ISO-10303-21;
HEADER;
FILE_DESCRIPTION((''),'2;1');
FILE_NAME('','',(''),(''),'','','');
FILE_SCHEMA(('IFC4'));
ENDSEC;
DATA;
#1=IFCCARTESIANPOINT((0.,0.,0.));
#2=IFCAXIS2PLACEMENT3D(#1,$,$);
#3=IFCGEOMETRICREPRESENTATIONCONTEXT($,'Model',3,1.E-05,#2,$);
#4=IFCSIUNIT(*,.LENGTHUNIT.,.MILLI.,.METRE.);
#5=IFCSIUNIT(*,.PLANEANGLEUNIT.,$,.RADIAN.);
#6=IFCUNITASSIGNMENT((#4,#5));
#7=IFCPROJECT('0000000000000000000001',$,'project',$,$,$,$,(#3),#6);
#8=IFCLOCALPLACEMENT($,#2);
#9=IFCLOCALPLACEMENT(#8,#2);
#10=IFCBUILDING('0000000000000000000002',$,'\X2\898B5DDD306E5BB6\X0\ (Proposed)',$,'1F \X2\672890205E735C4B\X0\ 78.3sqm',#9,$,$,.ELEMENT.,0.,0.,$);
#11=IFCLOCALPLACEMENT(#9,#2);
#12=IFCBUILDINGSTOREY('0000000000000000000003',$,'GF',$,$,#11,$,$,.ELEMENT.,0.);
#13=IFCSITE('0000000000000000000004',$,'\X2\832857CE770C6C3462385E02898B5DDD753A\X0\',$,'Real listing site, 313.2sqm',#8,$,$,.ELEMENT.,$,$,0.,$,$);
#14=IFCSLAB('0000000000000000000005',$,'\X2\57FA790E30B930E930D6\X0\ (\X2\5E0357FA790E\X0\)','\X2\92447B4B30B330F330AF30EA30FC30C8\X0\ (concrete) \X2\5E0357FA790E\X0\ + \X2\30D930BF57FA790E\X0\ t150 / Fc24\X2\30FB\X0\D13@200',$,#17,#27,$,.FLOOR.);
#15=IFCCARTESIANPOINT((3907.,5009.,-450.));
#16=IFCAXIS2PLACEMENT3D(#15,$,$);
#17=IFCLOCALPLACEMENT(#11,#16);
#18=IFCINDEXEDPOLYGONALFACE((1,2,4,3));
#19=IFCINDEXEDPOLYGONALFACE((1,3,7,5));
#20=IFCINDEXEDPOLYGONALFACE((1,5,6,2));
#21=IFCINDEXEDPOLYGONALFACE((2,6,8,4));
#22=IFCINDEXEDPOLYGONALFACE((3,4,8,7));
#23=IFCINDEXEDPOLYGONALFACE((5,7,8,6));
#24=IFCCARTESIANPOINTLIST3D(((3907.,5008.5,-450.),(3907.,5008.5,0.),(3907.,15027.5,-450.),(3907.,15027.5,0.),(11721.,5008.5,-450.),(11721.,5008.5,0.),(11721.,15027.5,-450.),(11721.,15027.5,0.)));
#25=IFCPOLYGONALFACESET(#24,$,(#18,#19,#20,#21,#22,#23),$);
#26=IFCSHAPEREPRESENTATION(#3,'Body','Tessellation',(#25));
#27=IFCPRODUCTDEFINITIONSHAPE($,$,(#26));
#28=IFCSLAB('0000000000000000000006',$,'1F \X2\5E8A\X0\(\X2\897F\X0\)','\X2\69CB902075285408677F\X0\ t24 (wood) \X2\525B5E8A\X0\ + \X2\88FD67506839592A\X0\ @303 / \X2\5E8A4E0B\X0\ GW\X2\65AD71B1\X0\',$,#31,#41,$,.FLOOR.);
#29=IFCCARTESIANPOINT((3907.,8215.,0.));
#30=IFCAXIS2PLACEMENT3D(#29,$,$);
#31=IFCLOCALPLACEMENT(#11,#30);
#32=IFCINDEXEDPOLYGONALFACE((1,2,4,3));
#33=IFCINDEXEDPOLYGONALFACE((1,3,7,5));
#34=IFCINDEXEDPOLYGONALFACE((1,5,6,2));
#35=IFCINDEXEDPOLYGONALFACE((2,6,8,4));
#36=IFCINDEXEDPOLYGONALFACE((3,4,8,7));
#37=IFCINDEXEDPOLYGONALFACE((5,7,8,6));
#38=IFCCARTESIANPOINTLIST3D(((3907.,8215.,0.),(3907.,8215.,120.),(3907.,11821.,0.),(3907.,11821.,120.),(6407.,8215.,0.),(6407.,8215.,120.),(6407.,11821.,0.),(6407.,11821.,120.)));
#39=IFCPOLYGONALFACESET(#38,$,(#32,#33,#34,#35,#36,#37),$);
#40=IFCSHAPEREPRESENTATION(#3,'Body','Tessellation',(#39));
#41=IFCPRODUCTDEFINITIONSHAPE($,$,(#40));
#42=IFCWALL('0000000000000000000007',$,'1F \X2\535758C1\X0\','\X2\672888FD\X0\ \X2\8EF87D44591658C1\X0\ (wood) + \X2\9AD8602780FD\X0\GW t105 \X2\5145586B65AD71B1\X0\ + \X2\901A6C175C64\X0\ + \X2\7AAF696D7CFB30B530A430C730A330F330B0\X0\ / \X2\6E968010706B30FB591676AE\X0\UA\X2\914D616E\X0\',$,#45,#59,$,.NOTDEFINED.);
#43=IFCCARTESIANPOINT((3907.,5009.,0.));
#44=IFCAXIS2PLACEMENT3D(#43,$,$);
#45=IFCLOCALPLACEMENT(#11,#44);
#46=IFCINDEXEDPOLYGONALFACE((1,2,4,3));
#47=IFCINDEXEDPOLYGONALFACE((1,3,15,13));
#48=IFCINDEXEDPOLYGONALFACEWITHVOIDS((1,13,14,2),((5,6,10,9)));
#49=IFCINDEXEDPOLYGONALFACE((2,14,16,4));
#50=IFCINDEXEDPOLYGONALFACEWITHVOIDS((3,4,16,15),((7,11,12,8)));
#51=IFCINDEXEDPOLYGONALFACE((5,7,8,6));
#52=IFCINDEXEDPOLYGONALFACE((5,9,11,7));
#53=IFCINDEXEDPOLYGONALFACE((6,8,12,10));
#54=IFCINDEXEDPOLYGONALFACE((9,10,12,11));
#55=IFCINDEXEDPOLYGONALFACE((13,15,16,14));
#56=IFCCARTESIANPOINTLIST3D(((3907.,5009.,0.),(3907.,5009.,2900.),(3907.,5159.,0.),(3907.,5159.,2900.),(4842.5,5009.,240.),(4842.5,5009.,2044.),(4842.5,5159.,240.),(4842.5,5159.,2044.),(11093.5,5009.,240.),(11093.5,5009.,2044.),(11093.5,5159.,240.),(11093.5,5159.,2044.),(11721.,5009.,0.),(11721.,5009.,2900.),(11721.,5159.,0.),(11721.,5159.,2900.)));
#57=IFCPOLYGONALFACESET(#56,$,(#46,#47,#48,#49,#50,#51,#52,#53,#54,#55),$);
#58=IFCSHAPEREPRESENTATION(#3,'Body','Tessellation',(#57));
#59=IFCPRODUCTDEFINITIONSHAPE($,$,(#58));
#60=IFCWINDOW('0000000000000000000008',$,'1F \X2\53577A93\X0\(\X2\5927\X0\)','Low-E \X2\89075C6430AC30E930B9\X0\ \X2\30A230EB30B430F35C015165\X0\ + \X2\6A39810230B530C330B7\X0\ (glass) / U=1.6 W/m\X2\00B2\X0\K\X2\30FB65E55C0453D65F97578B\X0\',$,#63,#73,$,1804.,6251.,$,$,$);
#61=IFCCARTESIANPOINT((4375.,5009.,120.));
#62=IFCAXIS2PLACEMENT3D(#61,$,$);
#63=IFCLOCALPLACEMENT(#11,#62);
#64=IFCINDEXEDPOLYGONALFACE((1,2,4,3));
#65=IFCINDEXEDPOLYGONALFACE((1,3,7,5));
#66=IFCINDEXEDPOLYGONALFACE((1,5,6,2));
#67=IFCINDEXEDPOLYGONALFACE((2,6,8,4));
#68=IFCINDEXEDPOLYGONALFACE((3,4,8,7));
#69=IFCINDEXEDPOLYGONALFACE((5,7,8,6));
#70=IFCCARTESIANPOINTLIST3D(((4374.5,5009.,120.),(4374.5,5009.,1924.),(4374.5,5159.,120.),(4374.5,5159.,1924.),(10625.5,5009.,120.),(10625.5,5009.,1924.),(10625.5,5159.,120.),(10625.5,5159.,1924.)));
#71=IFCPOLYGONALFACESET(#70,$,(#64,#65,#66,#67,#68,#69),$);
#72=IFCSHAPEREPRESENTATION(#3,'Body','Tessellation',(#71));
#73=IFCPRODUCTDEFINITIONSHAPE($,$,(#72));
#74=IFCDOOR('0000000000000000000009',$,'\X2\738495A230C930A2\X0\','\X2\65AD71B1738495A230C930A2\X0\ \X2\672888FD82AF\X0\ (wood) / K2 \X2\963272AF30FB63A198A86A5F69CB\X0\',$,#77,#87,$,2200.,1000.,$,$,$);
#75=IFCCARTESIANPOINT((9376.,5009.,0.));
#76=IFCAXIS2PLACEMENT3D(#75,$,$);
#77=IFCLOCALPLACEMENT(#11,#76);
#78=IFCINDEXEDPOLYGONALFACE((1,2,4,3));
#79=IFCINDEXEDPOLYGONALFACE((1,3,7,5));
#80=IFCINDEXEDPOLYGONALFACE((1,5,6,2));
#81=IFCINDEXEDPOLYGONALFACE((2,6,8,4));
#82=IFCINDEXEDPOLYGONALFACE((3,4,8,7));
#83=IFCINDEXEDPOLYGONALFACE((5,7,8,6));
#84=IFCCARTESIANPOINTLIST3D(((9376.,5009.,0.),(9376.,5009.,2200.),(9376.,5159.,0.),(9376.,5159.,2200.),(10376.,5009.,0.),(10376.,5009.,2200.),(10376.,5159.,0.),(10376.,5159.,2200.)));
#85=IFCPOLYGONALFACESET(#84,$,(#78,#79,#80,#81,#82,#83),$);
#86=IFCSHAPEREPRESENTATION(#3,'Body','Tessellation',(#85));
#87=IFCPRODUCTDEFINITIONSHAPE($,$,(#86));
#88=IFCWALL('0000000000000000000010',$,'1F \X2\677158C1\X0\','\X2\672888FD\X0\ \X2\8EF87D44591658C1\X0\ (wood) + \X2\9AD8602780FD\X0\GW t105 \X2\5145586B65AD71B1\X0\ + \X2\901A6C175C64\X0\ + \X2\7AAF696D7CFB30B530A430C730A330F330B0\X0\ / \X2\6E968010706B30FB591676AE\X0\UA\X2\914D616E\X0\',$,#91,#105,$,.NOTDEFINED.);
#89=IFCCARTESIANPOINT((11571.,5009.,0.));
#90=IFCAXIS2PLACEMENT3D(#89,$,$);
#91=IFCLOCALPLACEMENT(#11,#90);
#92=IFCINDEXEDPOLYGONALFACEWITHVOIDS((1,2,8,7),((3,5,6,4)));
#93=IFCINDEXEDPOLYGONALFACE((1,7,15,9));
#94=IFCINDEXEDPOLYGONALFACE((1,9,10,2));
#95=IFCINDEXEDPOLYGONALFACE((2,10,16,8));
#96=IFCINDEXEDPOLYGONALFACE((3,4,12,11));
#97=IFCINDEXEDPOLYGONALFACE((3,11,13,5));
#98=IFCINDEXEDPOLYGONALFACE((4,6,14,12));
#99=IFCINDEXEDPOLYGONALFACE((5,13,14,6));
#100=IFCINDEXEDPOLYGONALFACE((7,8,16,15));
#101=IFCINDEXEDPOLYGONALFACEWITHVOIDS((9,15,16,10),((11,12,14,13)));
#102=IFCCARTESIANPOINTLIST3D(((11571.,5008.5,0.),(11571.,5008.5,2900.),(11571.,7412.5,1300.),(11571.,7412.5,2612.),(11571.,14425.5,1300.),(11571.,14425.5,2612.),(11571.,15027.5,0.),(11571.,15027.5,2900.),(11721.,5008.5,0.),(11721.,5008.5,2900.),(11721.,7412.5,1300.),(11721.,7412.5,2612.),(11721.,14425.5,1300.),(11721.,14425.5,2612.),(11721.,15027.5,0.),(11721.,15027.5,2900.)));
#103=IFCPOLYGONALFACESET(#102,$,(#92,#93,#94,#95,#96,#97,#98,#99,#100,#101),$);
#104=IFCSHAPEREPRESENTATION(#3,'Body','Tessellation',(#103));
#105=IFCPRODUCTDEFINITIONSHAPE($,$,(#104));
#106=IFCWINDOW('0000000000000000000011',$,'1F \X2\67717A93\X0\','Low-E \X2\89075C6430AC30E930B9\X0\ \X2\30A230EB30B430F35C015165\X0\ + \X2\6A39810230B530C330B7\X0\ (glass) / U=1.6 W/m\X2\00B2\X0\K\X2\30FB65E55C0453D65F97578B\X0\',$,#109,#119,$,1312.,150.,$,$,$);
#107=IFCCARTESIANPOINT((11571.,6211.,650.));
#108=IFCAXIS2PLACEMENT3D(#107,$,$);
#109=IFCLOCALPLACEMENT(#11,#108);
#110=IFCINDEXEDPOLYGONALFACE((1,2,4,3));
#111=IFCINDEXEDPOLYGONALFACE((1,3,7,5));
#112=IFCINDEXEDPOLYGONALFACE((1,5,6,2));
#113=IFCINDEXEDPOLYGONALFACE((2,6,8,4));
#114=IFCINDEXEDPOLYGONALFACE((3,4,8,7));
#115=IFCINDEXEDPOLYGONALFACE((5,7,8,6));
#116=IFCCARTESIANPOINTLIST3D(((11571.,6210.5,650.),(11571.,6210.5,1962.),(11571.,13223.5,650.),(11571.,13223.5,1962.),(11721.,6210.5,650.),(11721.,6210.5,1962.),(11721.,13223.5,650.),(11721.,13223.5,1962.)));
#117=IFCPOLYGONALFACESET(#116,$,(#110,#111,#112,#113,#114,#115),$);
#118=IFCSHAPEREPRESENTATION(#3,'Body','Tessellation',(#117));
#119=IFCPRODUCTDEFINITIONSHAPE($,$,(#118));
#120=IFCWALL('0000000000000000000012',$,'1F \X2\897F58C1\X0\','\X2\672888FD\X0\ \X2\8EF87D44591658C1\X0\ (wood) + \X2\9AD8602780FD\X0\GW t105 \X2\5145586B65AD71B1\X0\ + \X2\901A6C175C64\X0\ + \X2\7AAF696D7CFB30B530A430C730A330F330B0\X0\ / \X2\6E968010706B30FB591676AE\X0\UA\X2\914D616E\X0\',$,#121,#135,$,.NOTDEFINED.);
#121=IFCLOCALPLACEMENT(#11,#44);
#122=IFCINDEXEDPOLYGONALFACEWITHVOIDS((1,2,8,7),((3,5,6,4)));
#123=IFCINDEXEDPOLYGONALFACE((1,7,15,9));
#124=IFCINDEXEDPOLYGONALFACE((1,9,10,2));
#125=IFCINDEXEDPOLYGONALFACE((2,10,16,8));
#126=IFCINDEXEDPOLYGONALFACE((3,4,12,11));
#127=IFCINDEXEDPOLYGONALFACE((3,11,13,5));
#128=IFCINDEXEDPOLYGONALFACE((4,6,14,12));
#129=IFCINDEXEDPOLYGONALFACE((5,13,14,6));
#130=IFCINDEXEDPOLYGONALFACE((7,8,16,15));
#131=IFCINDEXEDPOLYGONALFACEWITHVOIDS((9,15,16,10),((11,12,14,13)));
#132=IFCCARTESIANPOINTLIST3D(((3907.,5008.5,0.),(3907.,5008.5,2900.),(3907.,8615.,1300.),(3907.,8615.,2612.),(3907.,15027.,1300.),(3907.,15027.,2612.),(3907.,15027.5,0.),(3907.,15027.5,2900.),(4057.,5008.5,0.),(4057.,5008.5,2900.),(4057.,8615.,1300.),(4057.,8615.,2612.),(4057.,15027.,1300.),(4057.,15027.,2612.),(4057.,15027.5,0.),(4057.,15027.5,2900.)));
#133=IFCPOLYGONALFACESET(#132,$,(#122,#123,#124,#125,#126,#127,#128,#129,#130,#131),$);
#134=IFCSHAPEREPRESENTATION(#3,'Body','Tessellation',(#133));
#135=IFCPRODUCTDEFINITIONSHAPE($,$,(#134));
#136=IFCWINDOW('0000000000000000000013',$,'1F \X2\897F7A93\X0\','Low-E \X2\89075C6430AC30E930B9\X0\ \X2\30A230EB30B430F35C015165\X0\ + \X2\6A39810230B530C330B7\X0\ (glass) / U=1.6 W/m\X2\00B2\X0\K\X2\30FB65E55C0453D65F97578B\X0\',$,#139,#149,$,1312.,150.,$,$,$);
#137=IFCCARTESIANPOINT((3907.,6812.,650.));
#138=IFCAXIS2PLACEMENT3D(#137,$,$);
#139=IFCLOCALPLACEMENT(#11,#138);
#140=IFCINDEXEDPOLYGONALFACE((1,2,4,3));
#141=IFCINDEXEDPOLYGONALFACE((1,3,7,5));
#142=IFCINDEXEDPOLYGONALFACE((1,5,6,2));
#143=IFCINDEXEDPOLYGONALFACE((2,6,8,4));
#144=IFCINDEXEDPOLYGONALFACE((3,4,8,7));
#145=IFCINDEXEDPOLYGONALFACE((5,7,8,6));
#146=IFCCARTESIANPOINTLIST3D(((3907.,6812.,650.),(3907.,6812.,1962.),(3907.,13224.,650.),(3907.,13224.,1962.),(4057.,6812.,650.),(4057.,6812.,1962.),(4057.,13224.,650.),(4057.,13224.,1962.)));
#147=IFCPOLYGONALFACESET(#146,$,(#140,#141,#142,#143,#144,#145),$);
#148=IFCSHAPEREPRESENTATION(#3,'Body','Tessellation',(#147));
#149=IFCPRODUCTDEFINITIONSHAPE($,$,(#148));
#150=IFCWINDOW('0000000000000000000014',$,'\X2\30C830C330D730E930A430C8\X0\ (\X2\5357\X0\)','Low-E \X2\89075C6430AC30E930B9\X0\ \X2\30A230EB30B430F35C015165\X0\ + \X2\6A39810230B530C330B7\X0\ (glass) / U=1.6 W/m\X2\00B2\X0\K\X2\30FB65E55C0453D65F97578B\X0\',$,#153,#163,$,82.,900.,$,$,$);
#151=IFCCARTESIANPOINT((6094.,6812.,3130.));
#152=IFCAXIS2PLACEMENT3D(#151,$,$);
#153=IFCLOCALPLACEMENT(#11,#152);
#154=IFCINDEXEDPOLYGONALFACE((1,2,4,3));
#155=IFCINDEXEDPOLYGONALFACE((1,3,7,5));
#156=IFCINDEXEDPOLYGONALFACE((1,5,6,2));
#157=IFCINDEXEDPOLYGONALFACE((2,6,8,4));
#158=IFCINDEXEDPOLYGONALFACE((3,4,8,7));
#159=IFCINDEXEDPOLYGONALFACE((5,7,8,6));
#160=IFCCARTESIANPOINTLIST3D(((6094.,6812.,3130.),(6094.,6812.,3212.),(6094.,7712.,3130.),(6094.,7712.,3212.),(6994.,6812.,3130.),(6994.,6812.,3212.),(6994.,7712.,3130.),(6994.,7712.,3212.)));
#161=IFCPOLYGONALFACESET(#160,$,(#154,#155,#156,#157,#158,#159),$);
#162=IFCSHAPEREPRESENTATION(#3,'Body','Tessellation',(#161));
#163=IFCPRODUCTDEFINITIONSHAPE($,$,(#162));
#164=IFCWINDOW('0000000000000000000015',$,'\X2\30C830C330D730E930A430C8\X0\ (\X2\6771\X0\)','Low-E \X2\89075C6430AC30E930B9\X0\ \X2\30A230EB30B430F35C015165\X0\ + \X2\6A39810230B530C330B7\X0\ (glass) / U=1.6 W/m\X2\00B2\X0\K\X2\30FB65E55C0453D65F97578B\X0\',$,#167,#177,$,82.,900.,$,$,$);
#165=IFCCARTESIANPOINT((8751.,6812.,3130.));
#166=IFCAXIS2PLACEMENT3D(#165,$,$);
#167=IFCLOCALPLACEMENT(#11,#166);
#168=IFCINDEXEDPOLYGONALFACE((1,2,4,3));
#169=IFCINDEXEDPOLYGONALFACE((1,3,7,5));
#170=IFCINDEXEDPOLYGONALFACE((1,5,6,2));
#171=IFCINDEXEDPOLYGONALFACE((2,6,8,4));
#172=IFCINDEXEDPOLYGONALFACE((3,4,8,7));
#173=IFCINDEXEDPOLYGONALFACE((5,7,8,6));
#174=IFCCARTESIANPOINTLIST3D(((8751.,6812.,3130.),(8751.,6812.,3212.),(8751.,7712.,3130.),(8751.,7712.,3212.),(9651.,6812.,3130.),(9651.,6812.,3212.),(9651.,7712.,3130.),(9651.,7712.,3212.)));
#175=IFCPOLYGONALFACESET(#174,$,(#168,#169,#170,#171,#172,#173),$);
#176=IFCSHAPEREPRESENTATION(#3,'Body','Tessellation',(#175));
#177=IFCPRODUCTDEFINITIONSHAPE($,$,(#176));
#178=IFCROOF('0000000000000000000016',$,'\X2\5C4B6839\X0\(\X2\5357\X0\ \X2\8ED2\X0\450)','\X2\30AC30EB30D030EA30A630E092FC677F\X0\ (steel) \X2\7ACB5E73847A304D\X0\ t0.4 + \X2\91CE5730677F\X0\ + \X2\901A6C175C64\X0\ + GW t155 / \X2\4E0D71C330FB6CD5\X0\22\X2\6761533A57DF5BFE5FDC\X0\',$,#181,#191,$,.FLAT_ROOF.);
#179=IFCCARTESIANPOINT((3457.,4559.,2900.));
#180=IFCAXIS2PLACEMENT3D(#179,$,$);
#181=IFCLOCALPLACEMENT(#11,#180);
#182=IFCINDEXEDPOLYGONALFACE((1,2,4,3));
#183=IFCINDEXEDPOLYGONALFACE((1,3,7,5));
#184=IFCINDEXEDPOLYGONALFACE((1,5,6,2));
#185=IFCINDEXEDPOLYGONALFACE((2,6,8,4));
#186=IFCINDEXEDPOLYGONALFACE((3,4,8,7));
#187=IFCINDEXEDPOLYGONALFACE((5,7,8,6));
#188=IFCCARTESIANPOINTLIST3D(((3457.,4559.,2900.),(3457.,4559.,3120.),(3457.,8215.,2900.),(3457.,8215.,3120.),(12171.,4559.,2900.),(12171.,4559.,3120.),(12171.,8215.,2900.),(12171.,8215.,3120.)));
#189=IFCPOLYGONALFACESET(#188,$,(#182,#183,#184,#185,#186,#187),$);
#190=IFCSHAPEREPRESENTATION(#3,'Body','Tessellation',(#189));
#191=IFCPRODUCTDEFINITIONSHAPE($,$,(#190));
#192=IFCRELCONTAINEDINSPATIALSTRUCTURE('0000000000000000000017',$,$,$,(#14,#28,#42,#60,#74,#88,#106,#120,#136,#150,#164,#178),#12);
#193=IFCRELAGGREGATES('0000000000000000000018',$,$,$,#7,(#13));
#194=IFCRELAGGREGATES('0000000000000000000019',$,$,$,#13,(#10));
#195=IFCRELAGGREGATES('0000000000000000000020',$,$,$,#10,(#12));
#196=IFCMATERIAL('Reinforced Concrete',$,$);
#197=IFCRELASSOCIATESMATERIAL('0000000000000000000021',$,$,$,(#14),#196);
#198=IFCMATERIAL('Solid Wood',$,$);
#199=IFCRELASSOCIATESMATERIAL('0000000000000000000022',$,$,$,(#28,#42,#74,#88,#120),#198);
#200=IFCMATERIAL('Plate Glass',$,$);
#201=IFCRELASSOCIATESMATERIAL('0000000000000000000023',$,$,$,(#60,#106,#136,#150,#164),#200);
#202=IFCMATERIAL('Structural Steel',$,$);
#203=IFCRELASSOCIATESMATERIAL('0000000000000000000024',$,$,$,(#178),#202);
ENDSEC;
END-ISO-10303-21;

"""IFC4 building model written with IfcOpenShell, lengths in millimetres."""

from ifc_helpers import new_model, si_unit, frame, frame_2d, origin, place, context, project, spatial, rectangle, extrude, material, element, fill, save


model = new_model("IFC4")

# Units and contexts
model_context = context("Model", 3, precision=1e-05, world=origin())
ifc_project = project(units=[si_unit("LENGTHUNIT", "METRE", prefix="MILLI"), si_unit("PLANEANGLEUNIT", "RADIAN")], contexts=[model_context])

# Site, building, storey
site_placement = place(None, origin())
site = spatial("IfcSite", under=ifc_project, at=site_placement, Name="茨城県水戸市見川町", ObjectType="Real listing site, 313.2sqm", CompositionType="ELEMENT", RefElevation=0.0)
building_placement = place(site_placement, origin())
building = spatial("IfcBuilding", under=site, at=building_placement, Name="見川の家 (Proposed)", ObjectType="1F 木造平屋 78.3sqm", CompositionType="ELEMENT", ElevationOfRefHeight=0.0, ElevationOfTerrain=0.0)
storey_placement = place(building_placement, origin())
storey = spatial("IfcBuildingStorey", under=building, at=storey_placement, Name="GF", CompositionType="ELEMENT", Elevation=0.0)

# Slabs
ifc_material_1 = material(Name="Reinforced Concrete")
slab_1_placement = place(storey_placement, frame((3907.0, 5009.0, -450.0)))
element("IfcSlab", 1, at=slab_1_placement, inside=storey, material=ifc_material_1, Name="基礎スラブ (布基礎)", Description="鉄筋コンクリート (concrete) 布基礎 + ベタ基礎 t150 / Fc24・D13@200", PredefinedType="FLOOR", context=model_context, shape_type="SweptSolid", body=[
    extrude(rectangle(XDim=7814.0, YDim=10019.0, at=frame_2d((3907.0, 5009.0))), frame((3907.0, 5009.0, -450.0)), (0.0, 0.0, 1.0), 450.0),
])
ifc_material_2 = material(Name="Solid Wood")
slab_2_placement = place(storey_placement, frame((3907.0, 8215.0, 0.0)))
element("IfcSlab", 2, at=slab_2_placement, inside=storey, material=ifc_material_2, Name="1F 床(西)", Description="構造用合板 t24 (wood) 剛床 + 製材根太 @303 / 床下 GW断熱", PredefinedType="FLOOR", context=model_context, shape_type="SweptSolid", body=[
    extrude(rectangle(XDim=2500.0, YDim=3606.0, at=frame_2d((1250.0, 1803.0))), frame((3907.0, 8215.0, 0.0)), (0.0, 0.0, 1.0), 120.0),
])

# Wall, openings, window, door
wall_1_placement = place(storey_placement, frame((3907.0, 5009.0, 0.0)))
wall_1 = element("IfcWall", 3, at=wall_1_placement, inside=storey, material=ifc_material_2, Name="1F 南壁", Description="木製 軸組外壁 (wood) + 高性能GW t105 充填断熱 + 通気層 + 窯業系サイディング / 準耐火・外皮UA配慮", PredefinedType="NOTDEFINED", context=model_context, shape_type="SweptSolid", body=[
    extrude(rectangle(XDim=7814.0, YDim=150.0, at=frame_2d((3907.0, 75.0))), frame((3907.0, 5009.0, 0.0)), (0.0, 0.0, 1.0), 2900.0),
])
opening_1_placement = place(storey_placement, frame((4375.0, 5009.0, 120.0)))
opening_1 = element("IfcOpeningElement", 4, at=opening_1_placement, cuts=wall_1, PredefinedType="NOTDEFINED", context=model_context, shape_type="SweptSolid", body=[
    extrude(rectangle(XDim=6251.0, YDim=150.0, at=frame_2d((3125.0, 75.0))), frame((4375.0, 5009.0, 120.0)), (0.0, 0.0, 1.0), 1804.0),
])
opening_2_placement = place(storey_placement, frame((9376.0, 5009.0, 0.0)))
opening_2 = element("IfcOpeningElement", 5, at=opening_2_placement, cuts=wall_1, PredefinedType="NOTDEFINED", context=model_context, shape_type="SweptSolid", body=[
    extrude(rectangle(XDim=1000.0, YDim=150.0, at=frame_2d((500.0, 75.0))), frame((9376.0, 5009.0, 0.0)), (0.0, 0.0, 1.0), 2200.0),
])
ifc_material_3 = material(Name="Plate Glass")
window_1_placement = place(storey_placement, frame((4375.0, 5009.0, 120.0)))
window_1 = element("IfcWindow", 6, at=window_1_placement, inside=storey, material=ifc_material_3, Name="1F 南窓(大)", Description="Low-E 複層ガラス アルゴン封入 + 樹脂サッシ (glass) / U=1.6 W/m²K・日射取得型", OverallHeight=1804.0, OverallWidth=6251.0, context=model_context, shape_type="SweptSolid", body=[
    extrude(rectangle(XDim=6251.0, YDim=150.0, at=frame_2d((3125.0, 75.0))), frame((4375.0, 5009.0, 120.0)), (0.0, 0.0, 1.0), 1804.0),
])
fill(opening_1, window_1)
door_placement = place(storey_placement, frame((9376.0, 5009.0, 0.0)))
door = element("IfcDoor", 7, at=door_placement, inside=storey, material=ifc_material_2, Name="玄関ドア", Description="断熱玄関ドア 木製芯 (wood) / K2 防犯・採風機構", OverallHeight=2200.0, OverallWidth=1000.0, context=model_context, shape_type="SweptSolid", body=[
    extrude(rectangle(XDim=1000.0, YDim=150.0, at=frame_2d((500.0, 75.0))), frame((9376.0, 5009.0, 0.0)), (0.0, 0.0, 1.0), 2200.0),
])
fill(opening_2, door)

# Walls, openings, windows
wall_2_placement = place(storey_placement, frame((11571.0, 5009.0, 0.0)))
wall_2 = element("IfcWall", 8, at=wall_2_placement, inside=storey, material=ifc_material_2, Name="1F 東壁", Description="木製 軸組外壁 (wood) + 高性能GW t105 充填断熱 + 通気層 + 窯業系サイディング / 準耐火・外皮UA配慮", PredefinedType="NOTDEFINED", context=model_context, shape_type="SweptSolid", body=[
    extrude(rectangle(XDim=150.0, YDim=10019.0, at=frame_2d((75.0, 5009.0))), frame((11571.0, 5009.0, 0.0)), (0.0, 0.0, 1.0), 2900.0),
])
opening_3_placement = place(storey_placement, frame((11571.0, 6211.0, 650.0)))
opening_3 = element("IfcOpeningElement", 9, at=opening_3_placement, cuts=wall_2, PredefinedType="NOTDEFINED", context=model_context, shape_type="SweptSolid", body=[
    extrude(rectangle(XDim=150.0, YDim=7013.0, at=frame_2d((75.0, 3506.0))), frame((11571.0, 6211.0, 650.0)), (0.0, 0.0, 1.0), 1312.0),
])
window_2_placement = place(storey_placement, frame((11571.0, 6211.0, 650.0)))
window_2 = element("IfcWindow", 10, at=window_2_placement, inside=storey, material=ifc_material_3, Name="1F 東窓", Description="Low-E 複層ガラス アルゴン封入 + 樹脂サッシ (glass) / U=1.6 W/m²K・日射取得型", OverallHeight=1312.0, OverallWidth=150.0, context=model_context, shape_type="SweptSolid", body=[
    extrude(rectangle(XDim=150.0, YDim=7013.0, at=frame_2d((75.0, 3506.0))), frame((11571.0, 6211.0, 650.0)), (0.0, 0.0, 1.0), 1312.0),
])
fill(opening_3, window_2)
wall_3_placement = place(storey_placement, frame((3907.0, 5009.0, 0.0)))
wall_3 = element("IfcWall", 11, at=wall_3_placement, inside=storey, material=ifc_material_2, Name="1F 西壁", Description="木製 軸組外壁 (wood) + 高性能GW t105 充填断熱 + 通気層 + 窯業系サイディング / 準耐火・外皮UA配慮", PredefinedType="NOTDEFINED", context=model_context, shape_type="SweptSolid", body=[
    extrude(rectangle(XDim=150.0, YDim=10019.0, at=frame_2d((75.0, 5009.0))), frame((3907.0, 5009.0, 0.0)), (0.0, 0.0, 1.0), 2900.0),
])
opening_4_placement = place(storey_placement, frame((3907.0, 6812.0, 650.0)))
opening_4 = element("IfcOpeningElement", 12, at=opening_4_placement, cuts=wall_3, PredefinedType="NOTDEFINED", context=model_context, shape_type="SweptSolid", body=[
    extrude(rectangle(XDim=150.0, YDim=6412.0, at=frame_2d((75.0, 3206.0))), frame((3907.0, 6812.0, 650.0)), (0.0, 0.0, 1.0), 1312.0),
])
window_3_placement = place(storey_placement, frame((3907.0, 6812.0, 650.0)))
window_3 = element("IfcWindow", 13, at=window_3_placement, inside=storey, material=ifc_material_3, Name="1F 西窓", Description="Low-E 複層ガラス アルゴン封入 + 樹脂サッシ (glass) / U=1.6 W/m²K・日射取得型", OverallHeight=1312.0, OverallWidth=150.0, context=model_context, shape_type="SweptSolid", body=[
    extrude(rectangle(XDim=150.0, YDim=6412.0, at=frame_2d((75.0, 3206.0))), frame((3907.0, 6812.0, 650.0)), (0.0, 0.0, 1.0), 1312.0),
])
fill(opening_4, window_3)

# Windows
window_4_placement = place(storey_placement, frame((6094.0, 6812.0, 3130.0)))
element("IfcWindow", 14, at=window_4_placement, inside=storey, material=ifc_material_3, Name="トップライト (南)", Description="Low-E 複層ガラス アルゴン封入 + 樹脂サッシ (glass) / U=1.6 W/m²K・日射取得型", OverallHeight=82.0, OverallWidth=900.0, context=model_context, shape_type="SweptSolid", body=[
    extrude(rectangle(XDim=900.0, YDim=900.0, at=frame_2d((450.0, 450.0))), frame((6094.0, 6812.0, 3130.0)), (0.0, 0.0, 1.0), 82.0),
])
window_5_placement = place(storey_placement, frame((8751.0, 6812.0, 3130.0)))
element("IfcWindow", 15, at=window_5_placement, inside=storey, material=ifc_material_3, Name="トップライト (東)", Description="Low-E 複層ガラス アルゴン封入 + 樹脂サッシ (glass) / U=1.6 W/m²K・日射取得型", OverallHeight=82.0, OverallWidth=900.0, context=model_context, shape_type="SweptSolid", body=[
    extrude(rectangle(XDim=900.0, YDim=900.0, at=frame_2d((450.0, 450.0))), frame((8751.0, 6812.0, 3130.0)), (0.0, 0.0, 1.0), 82.0),
])

# Roof
ifc_material_4 = material(Name="Structural Steel")
roof_placement = place(storey_placement, frame((3457.0, 4559.0, 2900.0)))
element("IfcRoof", 16, at=roof_placement, inside=storey, material=ifc_material_4, Name="屋根(南 軒450)", Description="ガルバリウム鋼板 (steel) 立平葺き t0.4 + 野地板 + 通気層 + GW t155 / 不燃・法22条区域対応", PredefinedType="FLAT_ROOF", context=model_context, shape_type="SweptSolid", body=[
    extrude(rectangle(XDim=8714.0, YDim=3656.0, at=frame_2d((4357.0, 1828.0))), frame((3457.0, 4559.0, 2900.0)), (0.0, 0.0, 1.0), 220.0),
])

save(model, "model.ifc")
